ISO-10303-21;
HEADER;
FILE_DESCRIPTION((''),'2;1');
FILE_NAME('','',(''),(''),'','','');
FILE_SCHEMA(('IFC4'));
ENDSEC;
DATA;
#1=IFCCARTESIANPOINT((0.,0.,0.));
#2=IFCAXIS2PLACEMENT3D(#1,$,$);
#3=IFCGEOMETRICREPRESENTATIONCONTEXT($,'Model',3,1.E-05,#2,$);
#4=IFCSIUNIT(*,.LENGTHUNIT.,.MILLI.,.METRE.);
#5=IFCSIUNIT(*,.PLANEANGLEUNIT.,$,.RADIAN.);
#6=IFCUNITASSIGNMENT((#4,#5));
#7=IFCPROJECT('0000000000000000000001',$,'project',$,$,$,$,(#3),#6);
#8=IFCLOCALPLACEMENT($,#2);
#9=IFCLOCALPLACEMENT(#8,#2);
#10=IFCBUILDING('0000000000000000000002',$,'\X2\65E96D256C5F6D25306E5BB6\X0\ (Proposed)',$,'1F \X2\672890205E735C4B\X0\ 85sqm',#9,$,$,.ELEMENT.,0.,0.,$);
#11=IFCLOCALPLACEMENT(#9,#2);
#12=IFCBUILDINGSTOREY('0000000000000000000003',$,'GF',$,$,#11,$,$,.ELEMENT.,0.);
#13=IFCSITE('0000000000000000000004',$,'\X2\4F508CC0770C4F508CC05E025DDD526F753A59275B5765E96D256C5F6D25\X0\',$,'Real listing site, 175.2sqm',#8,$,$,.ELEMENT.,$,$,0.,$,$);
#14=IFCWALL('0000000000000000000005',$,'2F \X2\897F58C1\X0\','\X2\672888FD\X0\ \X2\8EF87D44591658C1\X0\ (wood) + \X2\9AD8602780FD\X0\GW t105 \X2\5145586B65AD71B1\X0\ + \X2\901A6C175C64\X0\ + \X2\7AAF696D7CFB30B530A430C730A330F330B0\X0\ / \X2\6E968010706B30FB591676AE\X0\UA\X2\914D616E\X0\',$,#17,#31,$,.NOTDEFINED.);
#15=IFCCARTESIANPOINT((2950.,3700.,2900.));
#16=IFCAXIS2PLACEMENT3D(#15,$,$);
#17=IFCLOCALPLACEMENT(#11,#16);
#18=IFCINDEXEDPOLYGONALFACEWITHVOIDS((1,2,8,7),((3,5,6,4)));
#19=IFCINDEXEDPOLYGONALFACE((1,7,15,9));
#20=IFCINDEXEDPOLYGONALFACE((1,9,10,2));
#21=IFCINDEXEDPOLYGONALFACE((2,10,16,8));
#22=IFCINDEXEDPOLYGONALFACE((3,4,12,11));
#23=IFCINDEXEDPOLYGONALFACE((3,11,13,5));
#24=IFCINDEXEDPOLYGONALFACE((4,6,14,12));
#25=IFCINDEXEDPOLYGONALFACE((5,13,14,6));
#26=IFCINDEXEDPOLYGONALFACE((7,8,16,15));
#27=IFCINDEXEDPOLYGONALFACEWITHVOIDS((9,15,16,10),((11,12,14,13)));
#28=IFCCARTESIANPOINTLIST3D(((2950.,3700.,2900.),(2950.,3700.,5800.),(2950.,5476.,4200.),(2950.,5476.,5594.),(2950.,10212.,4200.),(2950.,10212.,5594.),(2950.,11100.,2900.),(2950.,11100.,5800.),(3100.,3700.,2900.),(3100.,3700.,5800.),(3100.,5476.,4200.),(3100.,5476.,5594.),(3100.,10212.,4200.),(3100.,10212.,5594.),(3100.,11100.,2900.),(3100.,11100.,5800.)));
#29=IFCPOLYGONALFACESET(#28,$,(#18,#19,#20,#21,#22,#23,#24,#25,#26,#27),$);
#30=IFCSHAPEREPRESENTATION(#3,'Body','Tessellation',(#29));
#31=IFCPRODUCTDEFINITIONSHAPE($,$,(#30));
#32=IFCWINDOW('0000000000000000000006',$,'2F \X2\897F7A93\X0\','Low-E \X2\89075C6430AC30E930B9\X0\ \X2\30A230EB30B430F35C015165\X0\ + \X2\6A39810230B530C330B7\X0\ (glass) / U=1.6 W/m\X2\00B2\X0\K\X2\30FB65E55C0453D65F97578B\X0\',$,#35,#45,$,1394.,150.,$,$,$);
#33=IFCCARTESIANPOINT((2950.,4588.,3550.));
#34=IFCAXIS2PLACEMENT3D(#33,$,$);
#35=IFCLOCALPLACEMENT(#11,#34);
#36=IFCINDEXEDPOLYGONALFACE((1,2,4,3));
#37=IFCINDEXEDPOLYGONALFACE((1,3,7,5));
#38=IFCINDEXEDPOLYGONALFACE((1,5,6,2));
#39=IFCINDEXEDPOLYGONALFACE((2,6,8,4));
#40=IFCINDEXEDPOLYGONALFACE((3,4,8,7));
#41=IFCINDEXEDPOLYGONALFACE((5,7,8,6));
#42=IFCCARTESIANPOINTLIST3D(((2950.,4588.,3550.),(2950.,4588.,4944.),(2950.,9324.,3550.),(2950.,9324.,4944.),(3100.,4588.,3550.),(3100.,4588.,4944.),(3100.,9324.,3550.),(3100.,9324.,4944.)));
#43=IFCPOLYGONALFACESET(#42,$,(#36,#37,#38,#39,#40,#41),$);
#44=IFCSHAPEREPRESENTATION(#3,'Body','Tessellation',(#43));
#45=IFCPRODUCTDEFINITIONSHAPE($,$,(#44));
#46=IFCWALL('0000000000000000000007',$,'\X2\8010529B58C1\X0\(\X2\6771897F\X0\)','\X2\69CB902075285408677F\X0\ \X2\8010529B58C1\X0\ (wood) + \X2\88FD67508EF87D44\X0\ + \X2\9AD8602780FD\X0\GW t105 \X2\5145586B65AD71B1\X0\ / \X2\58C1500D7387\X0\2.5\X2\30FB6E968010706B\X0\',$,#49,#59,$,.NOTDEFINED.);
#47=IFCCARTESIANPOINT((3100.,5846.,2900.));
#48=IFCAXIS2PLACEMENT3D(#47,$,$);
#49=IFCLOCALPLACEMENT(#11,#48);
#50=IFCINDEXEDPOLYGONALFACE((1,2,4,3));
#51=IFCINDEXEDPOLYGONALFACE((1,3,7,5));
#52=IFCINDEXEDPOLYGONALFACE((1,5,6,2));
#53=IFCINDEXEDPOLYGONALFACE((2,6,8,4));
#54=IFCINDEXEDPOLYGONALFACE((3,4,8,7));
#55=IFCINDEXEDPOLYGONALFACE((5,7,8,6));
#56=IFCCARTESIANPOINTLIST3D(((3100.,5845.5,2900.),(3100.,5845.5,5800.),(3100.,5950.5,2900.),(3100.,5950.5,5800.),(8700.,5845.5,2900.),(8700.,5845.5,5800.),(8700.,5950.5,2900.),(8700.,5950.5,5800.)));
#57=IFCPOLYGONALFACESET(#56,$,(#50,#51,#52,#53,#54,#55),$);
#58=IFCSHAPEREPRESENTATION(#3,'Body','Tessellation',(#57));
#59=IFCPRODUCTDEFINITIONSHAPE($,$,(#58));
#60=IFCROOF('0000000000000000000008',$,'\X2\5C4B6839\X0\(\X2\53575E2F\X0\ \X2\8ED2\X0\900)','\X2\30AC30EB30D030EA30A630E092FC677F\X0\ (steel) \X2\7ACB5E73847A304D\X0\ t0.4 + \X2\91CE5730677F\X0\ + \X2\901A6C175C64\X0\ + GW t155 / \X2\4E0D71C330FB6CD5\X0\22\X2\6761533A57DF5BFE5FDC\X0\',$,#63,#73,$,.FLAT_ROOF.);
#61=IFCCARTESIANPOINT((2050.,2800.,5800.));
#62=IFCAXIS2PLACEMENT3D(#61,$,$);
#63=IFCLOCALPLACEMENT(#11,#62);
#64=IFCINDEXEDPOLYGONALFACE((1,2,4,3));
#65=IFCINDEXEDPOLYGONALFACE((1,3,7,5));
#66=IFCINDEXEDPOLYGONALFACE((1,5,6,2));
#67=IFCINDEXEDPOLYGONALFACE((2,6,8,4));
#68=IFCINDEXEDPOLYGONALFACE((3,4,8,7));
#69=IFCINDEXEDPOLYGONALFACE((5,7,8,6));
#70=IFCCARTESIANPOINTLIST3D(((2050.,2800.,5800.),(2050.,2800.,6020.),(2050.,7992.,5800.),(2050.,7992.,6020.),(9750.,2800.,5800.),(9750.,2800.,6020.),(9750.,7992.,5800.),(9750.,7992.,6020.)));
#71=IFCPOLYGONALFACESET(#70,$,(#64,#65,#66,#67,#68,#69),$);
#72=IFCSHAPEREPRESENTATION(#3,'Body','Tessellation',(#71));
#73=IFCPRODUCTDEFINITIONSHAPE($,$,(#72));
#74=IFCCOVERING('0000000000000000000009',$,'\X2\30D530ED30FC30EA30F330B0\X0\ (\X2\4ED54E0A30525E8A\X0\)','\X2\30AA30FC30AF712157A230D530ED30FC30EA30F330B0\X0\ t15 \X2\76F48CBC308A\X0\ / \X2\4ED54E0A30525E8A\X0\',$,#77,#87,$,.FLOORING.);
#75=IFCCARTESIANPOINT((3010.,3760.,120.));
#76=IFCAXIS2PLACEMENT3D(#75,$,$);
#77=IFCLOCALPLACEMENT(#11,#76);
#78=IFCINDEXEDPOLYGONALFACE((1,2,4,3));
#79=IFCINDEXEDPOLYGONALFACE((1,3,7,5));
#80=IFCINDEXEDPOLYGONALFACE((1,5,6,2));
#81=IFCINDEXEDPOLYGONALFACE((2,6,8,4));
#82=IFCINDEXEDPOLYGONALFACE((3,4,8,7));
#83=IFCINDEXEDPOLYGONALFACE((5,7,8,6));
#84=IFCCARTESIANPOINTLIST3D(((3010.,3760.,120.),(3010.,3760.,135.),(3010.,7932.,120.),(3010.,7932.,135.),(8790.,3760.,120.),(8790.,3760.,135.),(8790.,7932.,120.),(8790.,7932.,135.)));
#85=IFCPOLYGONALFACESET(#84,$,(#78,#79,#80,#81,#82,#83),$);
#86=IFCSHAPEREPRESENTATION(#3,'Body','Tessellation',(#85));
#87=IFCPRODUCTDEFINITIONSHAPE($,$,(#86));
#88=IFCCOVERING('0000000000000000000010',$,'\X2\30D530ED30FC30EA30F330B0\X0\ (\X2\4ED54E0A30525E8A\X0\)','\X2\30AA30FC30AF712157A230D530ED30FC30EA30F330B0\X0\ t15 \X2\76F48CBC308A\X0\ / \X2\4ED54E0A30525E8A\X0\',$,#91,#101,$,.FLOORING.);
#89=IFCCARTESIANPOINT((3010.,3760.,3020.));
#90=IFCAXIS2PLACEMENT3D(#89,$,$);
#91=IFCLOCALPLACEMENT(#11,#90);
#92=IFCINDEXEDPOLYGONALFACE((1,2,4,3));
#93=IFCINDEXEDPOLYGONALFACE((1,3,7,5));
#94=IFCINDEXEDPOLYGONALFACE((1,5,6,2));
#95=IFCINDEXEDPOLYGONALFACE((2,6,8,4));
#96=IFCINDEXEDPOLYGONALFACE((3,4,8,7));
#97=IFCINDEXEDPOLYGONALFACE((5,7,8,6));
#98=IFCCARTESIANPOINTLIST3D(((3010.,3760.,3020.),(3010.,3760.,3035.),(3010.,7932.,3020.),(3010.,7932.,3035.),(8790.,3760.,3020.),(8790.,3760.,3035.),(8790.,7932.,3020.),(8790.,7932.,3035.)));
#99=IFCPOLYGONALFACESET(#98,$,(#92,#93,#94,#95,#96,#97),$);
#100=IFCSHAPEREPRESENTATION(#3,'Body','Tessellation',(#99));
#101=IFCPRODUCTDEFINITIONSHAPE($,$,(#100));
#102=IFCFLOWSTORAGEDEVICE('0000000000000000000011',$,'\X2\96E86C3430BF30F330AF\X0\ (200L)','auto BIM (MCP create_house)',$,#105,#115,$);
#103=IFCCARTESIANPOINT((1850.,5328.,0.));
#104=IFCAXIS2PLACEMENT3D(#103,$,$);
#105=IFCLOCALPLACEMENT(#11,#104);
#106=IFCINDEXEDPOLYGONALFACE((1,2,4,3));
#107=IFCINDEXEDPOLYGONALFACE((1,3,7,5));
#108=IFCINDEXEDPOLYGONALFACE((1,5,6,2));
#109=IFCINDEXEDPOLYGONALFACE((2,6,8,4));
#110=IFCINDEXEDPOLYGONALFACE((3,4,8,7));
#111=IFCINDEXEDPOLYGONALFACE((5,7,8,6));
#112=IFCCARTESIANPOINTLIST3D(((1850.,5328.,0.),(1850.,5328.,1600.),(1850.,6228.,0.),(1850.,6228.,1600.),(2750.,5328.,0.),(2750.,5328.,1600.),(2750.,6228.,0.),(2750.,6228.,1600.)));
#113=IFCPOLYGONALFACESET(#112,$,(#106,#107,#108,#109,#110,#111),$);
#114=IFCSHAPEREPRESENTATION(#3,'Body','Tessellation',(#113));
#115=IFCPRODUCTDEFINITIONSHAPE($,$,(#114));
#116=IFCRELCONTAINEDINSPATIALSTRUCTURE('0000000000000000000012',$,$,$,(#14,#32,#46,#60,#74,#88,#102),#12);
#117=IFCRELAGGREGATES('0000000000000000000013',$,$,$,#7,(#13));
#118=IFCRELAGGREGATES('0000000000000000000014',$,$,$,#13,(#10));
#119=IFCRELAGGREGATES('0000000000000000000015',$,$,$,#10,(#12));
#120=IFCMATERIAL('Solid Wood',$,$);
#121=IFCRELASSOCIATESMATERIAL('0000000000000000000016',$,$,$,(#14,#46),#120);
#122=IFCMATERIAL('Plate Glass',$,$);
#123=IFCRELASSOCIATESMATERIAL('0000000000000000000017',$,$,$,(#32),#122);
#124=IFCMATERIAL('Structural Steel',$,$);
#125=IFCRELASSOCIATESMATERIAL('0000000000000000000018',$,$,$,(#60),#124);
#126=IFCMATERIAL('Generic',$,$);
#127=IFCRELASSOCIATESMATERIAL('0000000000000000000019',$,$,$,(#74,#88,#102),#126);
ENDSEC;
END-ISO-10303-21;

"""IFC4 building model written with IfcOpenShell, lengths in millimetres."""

from ifc_helpers import new_model, si_unit, frame, frame_2d, origin, place, context, project, spatial, rectangle, extrude, material, element, fill, save


model = new_model("IFC4")

# Units and contexts
model_context = context("Model", 3, precision=1e-05, world=origin())
ifc_project = project(units=[si_unit("LENGTHUNIT", "METRE", prefix="MILLI"), si_unit("PLANEANGLEUNIT", "RADIAN")], contexts=[model_context])

# Site, building, storey
site_placement = place(None, origin())
site = spatial("IfcSite", under=ifc_project, at=site_placement, Name="佐賀県佐賀市川副町大字早津江津", ObjectType="Real listing site, 175.2sqm", CompositionType="ELEMENT", RefElevation=0.0)
building_placement = place(site_placement, origin())
building = spatial("IfcBuilding", under=site, at=building_placement, Name="早津江津の家 (Proposed)", ObjectType="1F 木造平屋 85sqm", CompositionType="ELEMENT", ElevationOfRefHeight=0.0, ElevationOfTerrain=0.0)
storey_placement = place(building_placement, origin())
storey = spatial("IfcBuildingStorey", under=building, at=storey_placement, Name="GF", CompositionType="ELEMENT", Elevation=0.0)

# Shared definitions
ifc_material_1 = material(Name="Solid Wood")
ifc_material_2 = material(Name="Generic")

# Shared definitions
ifc_material_3 = material(Name="Plate Glass")

# Wall, opening, window
wall_1_placement = place(storey_placement, frame((2950.0, 3700.0, 2900.0)))
wall_1 = element("IfcWall", 1, at=wall_1_placement, inside=storey, material=ifc_material_1, Name="2F 西壁", Description="木製 軸組外壁 (wood) + 高性能GW t105 充填断熱 + 通気層 + 窯業系サイディング / 準耐火・外皮UA配慮", PredefinedType="NOTDEFINED", context=model_context, shape_type="SweptSolid", body=[
    extrude(rectangle(XDim=150.0, YDim=7400.0, at=frame_2d((75.0, 3700.0))), frame((2950.0, 3700.0, 2900.0)), (0.0, 0.0, 1.0), 2900.0),
])
opening_1_placement = place(storey_placement, frame((2950.0, 4588.0, 3550.0)))
opening_1 = element("IfcOpeningElement", 2, at=opening_1_placement, cuts=wall_1, PredefinedType="NOTDEFINED", context=model_context, shape_type="SweptSolid", body=[
    extrude(rectangle(XDim=150.0, YDim=4736.0, at=frame_2d((75.0, 2368.0))), frame((2950.0, 4588.0, 3550.0)), (0.0, 0.0, 1.0), 1394.0),
])
window_1_placement = place(storey_placement, frame((2950.0, 4588.0, 3550.0)))
window_1 = element("IfcWindow", 3, at=window_1_placement, inside=storey, material=ifc_material_3, Name="2F 西窓", Description="Low-E 複層ガラス アルゴン封入 + 樹脂サッシ (glass) / U=1.6 W/m²K・日射取得型", OverallHeight=1394.0, OverallWidth=150.0, context=model_context, shape_type="SweptSolid", body=[
    extrude(rectangle(XDim=150.0, YDim=4736.0, at=frame_2d((75.0, 2368.0))), frame((2950.0, 4588.0, 3550.0)), (0.0, 0.0, 1.0), 1394.0),
])
fill(opening_1, window_1)

# Wall
wall_2_placement = place(storey_placement, frame((3100.0, 5846.0, 2900.0)))
element("IfcWall", 4, at=wall_2_placement, inside=storey, material=ifc_material_1, Name="耐力壁(東西)", Description="構造用合板 耐力壁 (wood) + 製材軸組 + 高性能GW t105 充填断熱 / 壁倍率2.5・準耐火", PredefinedType="NOTDEFINED", context=model_context, shape_type="SweptSolid", body=[
    extrude(rectangle(XDim=5600.0, YDim=105.0, at=frame_2d((2800.0, 52.0))), frame((3100.0, 5846.0, 2900.0)), (0.0, 0.0, 1.0), 2900.0),
])

# Roof
ifc_material_4 = material(Name="Structural Steel")
for number, where, name in (
    (5, (2050.0, 2800.0, 5800.0), "屋根(南帯 軒900)"),
):
    element("IfcRoof", number, at=place(storey_placement, frame(where)), inside=storey, material=ifc_material_4, Name=name, Description="ガルバリウム鋼板 (steel) 立平葺き t0.4 + 野地板 + 通気層 + GW t155 / 不燃・法22条区域対応", PredefinedType="FLAT_ROOF", context=model_context, shape_type="SweptSolid", body=[
        extrude(rectangle(XDim=7700.0, YDim=5192.0, at=frame_2d((3850.0, 2596.0))), frame((2050.0, 2800.0, 5800.0)), (0.0, 0.0, 1.0), 220.0),
    ])

# Coverings
covering_1_placement = place(storey_placement, frame((3010.0, 3760.0, 120.0)))
element("IfcCovering", 6, at=covering_1_placement, inside=storey, material=ifc_material_2, Name="フローリング (仕上げ床)", Description="オーク無垢フローリング t15 直貼り / 仕上げ床", PredefinedType="FLOORING", context=model_context, shape_type="SweptSolid", body=[
    extrude(rectangle(XDim=5780.0, YDim=4172.0, at=frame_2d((2890.0, 2086.0))), frame((3010.0, 3760.0, 120.0)), (0.0, 0.0, 1.0), 15.0),
])
covering_2_placement = place(storey_placement, frame((3010.0, 3760.0, 3020.0)))
element("IfcCovering", 7, at=covering_2_placement, inside=storey, material=ifc_material_2, Name="フローリング (仕上げ床)", Description="オーク無垢フローリング t15 直貼り / 仕上げ床", PredefinedType="FLOORING", context=model_context, shape_type="SweptSolid", body=[
    extrude(rectangle(XDim=5780.0, YDim=4172.0, at=frame_2d((2890.0, 2086.0))), frame((3010.0, 3760.0, 3020.0)), (0.0, 0.0, 1.0), 15.0),
])

# Flow storage device
flow_storage_device_placement = place(storey_placement, frame((1850.0, 5328.0, 0.0)))
element("IfcFlowStorageDevice", 8, at=flow_storage_device_placement, inside=storey, material=ifc_material_2, Name="雨水タンク (200L)", Description="auto BIM (MCP create_house)", context=model_context, shape_type="SweptSolid", body=[
    extrude(rectangle(XDim=900.0, YDim=900.0, at=frame_2d((450.0, 450.0))), frame((1850.0, 5328.0, 0.0)), (0.0, 0.0, 1.0), 1600.0),
])

save(model, "model.ifc")
